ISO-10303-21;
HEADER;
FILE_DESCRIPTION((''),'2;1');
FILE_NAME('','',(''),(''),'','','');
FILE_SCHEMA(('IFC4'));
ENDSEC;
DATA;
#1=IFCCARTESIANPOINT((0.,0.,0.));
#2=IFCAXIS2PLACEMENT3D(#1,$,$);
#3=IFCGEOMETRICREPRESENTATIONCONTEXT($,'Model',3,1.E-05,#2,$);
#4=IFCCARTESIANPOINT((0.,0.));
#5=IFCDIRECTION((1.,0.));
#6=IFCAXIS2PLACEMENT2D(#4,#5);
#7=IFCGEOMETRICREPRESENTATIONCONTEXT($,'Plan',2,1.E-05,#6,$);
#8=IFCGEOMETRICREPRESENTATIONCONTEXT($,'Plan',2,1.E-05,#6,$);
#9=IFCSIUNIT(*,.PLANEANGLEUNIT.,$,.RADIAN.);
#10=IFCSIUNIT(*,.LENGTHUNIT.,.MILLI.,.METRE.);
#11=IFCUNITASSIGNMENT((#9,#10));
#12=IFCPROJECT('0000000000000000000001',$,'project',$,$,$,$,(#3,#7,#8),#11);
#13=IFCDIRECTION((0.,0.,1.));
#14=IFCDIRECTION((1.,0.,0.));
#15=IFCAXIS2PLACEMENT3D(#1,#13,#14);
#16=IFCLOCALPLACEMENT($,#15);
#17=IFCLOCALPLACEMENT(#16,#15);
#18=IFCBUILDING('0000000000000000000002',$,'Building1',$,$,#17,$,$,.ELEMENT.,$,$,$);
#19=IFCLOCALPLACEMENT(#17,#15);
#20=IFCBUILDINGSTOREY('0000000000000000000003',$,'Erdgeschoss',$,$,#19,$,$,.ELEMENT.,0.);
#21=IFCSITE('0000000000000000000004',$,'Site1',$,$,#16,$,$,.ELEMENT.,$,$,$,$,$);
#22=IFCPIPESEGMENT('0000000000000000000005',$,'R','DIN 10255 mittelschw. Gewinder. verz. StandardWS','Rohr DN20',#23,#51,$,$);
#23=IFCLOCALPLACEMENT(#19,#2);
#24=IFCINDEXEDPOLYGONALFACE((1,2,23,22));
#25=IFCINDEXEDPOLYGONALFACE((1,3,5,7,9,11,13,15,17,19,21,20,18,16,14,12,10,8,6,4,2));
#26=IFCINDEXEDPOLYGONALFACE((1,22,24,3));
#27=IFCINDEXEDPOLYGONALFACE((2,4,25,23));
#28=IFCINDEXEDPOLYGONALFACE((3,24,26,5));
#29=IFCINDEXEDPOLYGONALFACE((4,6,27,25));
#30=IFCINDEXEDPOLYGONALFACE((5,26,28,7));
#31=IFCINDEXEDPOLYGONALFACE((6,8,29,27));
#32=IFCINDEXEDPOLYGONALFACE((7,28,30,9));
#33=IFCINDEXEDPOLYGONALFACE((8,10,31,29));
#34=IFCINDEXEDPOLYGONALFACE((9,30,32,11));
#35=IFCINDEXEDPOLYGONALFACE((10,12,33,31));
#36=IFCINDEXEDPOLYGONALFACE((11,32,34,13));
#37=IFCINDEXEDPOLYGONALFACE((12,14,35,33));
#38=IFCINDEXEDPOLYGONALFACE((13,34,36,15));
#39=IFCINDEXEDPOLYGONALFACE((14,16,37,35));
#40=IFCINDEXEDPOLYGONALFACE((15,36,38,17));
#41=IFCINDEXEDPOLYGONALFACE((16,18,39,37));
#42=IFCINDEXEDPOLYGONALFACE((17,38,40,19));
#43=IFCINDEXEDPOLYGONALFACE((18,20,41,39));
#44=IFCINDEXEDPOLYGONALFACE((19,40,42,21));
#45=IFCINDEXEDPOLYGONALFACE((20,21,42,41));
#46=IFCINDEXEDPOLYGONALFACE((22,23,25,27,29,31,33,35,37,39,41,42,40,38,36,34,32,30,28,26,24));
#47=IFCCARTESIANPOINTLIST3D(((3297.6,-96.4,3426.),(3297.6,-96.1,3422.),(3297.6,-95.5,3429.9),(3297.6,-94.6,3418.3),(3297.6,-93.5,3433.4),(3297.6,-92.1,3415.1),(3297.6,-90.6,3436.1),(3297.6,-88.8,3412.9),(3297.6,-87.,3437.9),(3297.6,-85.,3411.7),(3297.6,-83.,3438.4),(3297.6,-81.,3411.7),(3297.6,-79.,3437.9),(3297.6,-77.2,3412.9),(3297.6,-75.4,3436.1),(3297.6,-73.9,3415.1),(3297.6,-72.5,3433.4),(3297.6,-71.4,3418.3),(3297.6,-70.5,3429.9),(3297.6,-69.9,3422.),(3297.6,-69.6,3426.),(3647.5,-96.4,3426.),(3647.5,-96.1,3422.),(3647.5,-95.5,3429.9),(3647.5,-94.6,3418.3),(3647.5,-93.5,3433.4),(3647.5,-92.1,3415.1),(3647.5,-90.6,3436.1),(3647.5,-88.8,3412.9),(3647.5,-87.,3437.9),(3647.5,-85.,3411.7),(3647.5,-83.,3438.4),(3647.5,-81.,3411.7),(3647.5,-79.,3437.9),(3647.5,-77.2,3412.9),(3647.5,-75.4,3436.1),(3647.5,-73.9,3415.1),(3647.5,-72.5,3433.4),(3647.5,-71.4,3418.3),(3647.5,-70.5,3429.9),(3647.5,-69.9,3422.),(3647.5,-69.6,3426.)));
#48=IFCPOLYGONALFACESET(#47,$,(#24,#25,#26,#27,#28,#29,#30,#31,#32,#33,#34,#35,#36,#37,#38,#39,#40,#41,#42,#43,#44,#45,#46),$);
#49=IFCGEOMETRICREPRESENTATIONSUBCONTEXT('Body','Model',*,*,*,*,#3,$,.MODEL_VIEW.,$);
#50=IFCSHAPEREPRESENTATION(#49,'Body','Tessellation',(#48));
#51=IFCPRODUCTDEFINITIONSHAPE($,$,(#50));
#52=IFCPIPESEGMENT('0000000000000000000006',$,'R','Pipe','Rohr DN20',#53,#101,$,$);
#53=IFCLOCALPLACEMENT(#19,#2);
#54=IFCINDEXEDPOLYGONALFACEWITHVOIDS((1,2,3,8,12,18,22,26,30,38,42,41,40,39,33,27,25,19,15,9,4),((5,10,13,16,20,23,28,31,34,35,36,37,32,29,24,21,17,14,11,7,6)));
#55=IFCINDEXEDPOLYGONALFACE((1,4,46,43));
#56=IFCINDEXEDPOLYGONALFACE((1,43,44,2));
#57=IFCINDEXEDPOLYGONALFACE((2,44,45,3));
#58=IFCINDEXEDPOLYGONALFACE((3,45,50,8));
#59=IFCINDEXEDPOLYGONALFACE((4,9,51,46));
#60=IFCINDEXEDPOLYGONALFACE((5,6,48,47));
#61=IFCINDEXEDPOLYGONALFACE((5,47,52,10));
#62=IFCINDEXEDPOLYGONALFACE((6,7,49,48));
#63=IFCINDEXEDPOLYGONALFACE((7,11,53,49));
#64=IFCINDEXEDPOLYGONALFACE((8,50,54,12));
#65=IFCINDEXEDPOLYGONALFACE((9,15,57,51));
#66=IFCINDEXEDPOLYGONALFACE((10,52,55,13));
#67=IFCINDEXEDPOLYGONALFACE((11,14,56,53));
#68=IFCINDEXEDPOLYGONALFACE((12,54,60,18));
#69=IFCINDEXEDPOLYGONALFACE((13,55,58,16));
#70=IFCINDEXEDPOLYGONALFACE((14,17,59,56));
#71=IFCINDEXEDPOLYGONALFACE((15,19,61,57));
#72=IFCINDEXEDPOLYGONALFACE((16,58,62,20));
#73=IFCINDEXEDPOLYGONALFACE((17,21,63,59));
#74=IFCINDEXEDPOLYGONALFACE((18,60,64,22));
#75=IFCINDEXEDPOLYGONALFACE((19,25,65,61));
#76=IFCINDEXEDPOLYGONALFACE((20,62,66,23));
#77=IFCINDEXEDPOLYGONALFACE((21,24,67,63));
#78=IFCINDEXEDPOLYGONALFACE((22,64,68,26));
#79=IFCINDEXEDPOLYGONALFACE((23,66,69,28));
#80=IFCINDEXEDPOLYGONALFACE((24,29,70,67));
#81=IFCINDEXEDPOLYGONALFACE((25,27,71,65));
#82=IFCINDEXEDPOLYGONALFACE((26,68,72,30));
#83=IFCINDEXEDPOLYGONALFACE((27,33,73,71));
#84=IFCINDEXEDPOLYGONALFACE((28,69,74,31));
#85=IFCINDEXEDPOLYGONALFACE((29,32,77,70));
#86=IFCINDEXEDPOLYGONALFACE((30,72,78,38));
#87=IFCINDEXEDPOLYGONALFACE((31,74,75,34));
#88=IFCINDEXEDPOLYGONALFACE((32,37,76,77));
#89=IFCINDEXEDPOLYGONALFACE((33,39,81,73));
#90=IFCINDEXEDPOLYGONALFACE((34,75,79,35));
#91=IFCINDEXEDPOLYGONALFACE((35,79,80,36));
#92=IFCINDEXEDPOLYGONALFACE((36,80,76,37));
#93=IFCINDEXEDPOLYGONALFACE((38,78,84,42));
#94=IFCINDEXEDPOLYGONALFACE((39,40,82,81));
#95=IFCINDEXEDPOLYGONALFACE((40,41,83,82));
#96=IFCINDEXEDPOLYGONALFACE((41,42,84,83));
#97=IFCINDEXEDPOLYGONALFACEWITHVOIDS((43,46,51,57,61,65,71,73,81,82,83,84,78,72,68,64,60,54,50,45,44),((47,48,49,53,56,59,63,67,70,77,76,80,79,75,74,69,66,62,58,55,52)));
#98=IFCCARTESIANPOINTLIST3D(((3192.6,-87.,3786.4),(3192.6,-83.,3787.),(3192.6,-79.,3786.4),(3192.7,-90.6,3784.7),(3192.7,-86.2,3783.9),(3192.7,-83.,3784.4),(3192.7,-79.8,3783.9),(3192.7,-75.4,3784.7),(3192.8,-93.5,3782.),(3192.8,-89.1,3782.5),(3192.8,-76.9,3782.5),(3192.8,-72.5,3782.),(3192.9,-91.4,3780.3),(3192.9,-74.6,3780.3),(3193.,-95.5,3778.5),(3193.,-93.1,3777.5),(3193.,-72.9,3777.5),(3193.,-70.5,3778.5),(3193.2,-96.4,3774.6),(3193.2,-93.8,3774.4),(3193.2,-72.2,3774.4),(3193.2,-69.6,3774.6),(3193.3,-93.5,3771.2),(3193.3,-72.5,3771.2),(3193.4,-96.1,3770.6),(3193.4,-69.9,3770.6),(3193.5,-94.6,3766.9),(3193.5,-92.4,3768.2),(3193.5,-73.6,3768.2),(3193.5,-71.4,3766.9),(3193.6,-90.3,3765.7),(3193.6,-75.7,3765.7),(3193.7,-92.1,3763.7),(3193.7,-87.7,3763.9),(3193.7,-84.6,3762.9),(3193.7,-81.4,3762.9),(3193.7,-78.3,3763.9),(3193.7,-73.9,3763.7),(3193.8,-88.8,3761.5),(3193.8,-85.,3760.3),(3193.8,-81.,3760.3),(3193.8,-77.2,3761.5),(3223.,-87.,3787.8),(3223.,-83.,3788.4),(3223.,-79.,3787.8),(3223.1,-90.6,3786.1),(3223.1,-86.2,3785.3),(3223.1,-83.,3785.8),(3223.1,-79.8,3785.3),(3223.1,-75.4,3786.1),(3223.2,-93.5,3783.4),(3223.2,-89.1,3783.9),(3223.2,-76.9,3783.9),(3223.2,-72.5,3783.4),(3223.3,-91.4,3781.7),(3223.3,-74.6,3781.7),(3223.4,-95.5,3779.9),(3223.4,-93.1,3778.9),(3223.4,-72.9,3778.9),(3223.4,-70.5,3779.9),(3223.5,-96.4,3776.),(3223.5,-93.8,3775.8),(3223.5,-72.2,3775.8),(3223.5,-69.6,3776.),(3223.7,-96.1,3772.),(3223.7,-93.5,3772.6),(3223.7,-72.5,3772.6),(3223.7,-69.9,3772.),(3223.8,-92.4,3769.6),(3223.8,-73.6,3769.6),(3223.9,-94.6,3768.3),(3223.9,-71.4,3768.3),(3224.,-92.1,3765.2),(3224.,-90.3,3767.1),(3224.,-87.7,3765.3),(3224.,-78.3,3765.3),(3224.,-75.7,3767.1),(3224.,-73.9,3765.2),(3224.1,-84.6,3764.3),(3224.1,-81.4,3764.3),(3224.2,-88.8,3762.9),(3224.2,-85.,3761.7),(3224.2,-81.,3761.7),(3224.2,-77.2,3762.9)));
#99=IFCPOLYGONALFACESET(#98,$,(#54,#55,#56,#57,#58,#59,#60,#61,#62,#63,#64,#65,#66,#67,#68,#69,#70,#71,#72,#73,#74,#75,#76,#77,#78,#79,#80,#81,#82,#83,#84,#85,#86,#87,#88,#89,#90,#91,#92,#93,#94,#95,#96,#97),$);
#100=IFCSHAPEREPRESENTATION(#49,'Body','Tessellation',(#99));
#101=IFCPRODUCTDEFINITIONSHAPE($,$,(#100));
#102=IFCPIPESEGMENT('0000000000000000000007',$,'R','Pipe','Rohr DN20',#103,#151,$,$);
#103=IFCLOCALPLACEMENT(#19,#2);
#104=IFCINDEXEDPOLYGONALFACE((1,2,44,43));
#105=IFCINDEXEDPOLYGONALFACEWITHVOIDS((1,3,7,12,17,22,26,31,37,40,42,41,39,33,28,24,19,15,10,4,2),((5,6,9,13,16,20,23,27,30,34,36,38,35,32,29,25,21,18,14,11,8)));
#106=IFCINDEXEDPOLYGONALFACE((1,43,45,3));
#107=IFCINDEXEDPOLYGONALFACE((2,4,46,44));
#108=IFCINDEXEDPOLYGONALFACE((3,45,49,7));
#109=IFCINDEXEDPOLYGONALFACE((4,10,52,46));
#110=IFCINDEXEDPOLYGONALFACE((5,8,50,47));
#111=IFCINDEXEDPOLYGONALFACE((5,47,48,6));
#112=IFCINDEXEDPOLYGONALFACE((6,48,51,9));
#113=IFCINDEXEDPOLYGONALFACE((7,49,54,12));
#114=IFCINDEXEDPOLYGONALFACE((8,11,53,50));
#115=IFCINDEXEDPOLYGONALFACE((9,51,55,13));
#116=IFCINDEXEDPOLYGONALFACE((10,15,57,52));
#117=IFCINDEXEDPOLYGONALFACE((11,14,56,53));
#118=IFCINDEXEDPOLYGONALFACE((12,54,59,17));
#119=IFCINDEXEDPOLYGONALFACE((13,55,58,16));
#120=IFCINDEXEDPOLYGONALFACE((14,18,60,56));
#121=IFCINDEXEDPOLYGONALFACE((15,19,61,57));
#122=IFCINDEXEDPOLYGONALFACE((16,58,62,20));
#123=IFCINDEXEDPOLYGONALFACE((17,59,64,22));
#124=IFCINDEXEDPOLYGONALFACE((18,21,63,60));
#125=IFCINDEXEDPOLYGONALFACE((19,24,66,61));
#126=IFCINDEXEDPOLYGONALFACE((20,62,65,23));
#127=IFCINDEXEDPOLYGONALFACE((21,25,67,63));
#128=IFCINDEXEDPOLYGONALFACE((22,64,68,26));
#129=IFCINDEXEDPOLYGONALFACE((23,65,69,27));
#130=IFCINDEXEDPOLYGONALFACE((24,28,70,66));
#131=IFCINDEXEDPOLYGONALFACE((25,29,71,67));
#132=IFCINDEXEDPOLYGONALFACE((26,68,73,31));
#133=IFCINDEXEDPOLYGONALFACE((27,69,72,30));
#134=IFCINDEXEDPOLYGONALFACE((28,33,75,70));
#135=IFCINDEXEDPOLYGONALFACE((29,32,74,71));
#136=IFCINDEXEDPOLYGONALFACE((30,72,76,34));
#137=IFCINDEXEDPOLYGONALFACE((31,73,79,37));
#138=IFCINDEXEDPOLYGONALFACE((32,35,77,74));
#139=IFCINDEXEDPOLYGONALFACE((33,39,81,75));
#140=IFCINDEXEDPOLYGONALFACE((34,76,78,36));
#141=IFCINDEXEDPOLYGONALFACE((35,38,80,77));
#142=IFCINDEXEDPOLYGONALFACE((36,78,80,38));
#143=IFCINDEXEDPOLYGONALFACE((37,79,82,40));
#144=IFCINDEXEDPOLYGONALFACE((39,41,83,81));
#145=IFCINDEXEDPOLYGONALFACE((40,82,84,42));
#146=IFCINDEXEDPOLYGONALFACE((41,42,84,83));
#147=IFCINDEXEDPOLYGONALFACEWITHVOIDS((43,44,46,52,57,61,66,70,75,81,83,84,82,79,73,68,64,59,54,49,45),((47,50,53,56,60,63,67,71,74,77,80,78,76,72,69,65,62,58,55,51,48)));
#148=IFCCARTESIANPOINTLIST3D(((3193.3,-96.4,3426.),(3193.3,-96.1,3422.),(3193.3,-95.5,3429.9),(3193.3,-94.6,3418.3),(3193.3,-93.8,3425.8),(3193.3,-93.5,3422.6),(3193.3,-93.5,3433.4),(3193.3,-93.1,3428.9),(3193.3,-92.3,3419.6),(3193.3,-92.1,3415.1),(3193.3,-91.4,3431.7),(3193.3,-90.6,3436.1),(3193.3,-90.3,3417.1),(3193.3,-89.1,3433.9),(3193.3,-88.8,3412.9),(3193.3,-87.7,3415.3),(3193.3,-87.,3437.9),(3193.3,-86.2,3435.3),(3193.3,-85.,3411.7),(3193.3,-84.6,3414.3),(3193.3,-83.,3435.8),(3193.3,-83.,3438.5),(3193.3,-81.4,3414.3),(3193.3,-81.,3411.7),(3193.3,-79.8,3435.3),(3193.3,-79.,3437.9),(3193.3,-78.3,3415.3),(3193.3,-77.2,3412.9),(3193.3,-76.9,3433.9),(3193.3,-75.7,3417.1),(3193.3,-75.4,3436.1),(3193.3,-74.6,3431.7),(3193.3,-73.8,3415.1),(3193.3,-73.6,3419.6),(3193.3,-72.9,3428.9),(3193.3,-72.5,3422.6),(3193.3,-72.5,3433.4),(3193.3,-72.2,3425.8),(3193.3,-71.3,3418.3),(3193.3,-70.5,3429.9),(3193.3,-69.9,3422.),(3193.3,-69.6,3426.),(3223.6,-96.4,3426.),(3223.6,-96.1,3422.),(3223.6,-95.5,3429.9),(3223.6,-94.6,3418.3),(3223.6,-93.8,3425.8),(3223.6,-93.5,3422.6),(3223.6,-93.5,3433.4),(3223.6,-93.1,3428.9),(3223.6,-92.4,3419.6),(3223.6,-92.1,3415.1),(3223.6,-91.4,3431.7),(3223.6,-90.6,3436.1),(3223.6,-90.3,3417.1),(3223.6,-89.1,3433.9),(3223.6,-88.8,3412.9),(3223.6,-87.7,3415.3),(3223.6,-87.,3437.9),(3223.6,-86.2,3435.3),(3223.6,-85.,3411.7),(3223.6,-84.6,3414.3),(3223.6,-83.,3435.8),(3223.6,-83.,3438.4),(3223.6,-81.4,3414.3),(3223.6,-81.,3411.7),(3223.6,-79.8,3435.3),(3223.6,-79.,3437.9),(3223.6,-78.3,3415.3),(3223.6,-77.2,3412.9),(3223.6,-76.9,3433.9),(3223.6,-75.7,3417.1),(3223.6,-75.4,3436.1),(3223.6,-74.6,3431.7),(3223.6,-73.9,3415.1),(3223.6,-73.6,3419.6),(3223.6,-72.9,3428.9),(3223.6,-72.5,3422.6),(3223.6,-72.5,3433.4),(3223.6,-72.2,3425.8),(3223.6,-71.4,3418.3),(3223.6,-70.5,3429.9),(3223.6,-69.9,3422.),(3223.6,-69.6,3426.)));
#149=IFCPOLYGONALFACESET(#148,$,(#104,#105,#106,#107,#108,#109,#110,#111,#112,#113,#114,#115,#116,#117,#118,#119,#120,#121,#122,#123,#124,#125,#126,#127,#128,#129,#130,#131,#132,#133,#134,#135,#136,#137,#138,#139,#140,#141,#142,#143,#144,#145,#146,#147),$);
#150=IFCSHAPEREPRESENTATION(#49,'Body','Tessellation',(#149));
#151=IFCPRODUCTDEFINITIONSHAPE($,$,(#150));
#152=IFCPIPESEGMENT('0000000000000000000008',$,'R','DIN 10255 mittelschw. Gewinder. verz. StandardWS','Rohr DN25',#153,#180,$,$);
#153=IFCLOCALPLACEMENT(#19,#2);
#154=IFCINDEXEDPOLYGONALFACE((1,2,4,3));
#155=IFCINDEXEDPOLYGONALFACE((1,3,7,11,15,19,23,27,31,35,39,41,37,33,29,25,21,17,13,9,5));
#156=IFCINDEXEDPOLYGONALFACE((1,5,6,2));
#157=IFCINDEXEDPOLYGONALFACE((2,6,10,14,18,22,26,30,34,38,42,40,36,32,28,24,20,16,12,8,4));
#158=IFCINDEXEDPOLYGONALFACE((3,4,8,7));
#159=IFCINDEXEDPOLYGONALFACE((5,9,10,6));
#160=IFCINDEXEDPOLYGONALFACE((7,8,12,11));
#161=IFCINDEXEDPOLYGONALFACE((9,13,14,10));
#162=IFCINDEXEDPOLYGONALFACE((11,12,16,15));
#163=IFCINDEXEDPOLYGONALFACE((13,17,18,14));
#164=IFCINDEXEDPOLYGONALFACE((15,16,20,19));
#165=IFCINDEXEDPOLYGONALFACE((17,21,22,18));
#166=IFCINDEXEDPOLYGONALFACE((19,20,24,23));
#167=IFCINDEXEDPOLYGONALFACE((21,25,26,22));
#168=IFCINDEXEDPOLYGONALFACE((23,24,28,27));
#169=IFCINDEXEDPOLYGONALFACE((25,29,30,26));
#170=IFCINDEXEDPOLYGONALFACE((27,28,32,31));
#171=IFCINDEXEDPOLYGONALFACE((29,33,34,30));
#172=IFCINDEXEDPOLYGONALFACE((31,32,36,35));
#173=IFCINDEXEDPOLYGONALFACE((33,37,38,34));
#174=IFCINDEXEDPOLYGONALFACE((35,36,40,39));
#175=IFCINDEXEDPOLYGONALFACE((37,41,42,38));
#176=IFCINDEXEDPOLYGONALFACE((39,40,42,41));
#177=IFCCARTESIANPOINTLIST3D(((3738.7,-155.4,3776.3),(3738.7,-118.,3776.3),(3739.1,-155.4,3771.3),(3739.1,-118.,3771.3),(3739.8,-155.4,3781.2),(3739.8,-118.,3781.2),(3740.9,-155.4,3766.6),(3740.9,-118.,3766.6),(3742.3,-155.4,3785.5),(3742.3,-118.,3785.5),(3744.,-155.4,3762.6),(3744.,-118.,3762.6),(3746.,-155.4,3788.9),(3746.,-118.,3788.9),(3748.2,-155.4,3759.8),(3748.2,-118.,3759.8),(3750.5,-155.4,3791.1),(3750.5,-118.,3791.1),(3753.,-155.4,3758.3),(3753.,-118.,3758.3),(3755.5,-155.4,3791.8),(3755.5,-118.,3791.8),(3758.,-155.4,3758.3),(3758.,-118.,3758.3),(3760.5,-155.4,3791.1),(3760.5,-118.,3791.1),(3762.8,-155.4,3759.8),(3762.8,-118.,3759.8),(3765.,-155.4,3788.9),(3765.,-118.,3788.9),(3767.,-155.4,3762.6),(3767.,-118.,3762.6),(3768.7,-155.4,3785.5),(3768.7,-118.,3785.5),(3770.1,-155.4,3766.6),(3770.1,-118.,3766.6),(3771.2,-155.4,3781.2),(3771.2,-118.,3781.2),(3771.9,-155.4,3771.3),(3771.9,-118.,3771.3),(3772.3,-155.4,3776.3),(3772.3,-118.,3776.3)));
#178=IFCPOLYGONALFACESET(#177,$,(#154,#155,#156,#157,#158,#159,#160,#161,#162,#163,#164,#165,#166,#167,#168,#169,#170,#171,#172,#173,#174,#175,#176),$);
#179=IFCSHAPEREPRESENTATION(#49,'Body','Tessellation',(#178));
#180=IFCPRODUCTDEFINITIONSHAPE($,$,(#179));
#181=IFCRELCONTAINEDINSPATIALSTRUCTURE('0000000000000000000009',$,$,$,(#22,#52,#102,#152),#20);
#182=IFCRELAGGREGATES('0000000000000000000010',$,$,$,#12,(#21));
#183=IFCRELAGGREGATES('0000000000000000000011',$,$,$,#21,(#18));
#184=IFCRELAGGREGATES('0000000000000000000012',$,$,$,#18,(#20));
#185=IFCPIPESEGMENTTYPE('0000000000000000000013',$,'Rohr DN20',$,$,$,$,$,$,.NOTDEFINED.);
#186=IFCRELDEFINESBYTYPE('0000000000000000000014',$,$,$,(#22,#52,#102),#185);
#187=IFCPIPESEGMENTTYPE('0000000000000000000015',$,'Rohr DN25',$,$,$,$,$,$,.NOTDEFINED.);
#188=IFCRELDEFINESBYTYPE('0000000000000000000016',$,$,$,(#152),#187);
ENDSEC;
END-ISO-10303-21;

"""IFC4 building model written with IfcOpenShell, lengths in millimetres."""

from ifc_helpers import new_model, si_unit, frame, origin, origin_with_axes, origin_2d_with_axis, place, context, subcontext, project, spatial, circle, hollow_circle, extrude, type_object, element, save


model = new_model("IFC4")

# Units and contexts
model_context = context("Model", 3, precision=1e-05, world=origin())
plan_context_1 = context("Plan", 2, precision=1e-05, world=origin_2d_with_axis())
plan_context_2 = context("Plan", 2, precision=1e-05, world=origin_2d_with_axis())
body_context = subcontext(model_context, "Body", "Model", "MODEL_VIEW")
ifc_project = project(units=[si_unit("PLANEANGLEUNIT", "RADIAN"), si_unit("LENGTHUNIT", "METRE", prefix="MILLI")], contexts=[model_context, plan_context_1, plan_context_2])

# Site, building, storey
site_placement = place(None, origin_with_axes())
site = spatial("IfcSite", under=ifc_project, at=site_placement, Name="Site1", CompositionType="ELEMENT")
building_placement = place(site_placement, origin_with_axes())
building = spatial("IfcBuilding", under=site, at=building_placement, Name="Building1", CompositionType="ELEMENT")
storey_placement = place(building_placement, origin_with_axes())
storey = spatial("IfcBuildingStorey", under=building, at=storey_placement, Name="Erdgeschoss", CompositionType="ELEMENT", Elevation=0.0)

# Pipe segments
pipe_segment_type_1 = type_object("IfcPipeSegmentType", Name="Rohr DN20", PredefinedType="NOTDEFINED")
pipe_segment_1_placement = place(storey_placement, frame((3472.5, -83.2, 3425.0), z_axis=(0.0, 0.0, 1.0), x_axis=(1.0, 0.0, 0.0)))
element("IfcPipeSegment", 1, at=pipe_segment_1_placement, inside=storey, type_object=pipe_segment_type_1, Name="R", Description="DIN 10255 mittelschw. Gewinder. verz. StandardWS", ObjectType="Rohr DN20", context=body_context, shape_type="SolidModel", body=[
    extrude(circle(Radius=13.4, at=origin_2d_with_axis()), frame((175.0, 0.2, 0.0), z_axis=(-1.0, 0.0, 0.0), x_axis=(0.0, 0.0, 1.0)), (0.0, 0.0, 1.0), 349.9),
])
pipe_segment_2_placement = place(storey_placement, frame((3208.4, -82.8, 3774.3), z_axis=(0.0, 0.0, 1.0), x_axis=(1.0, 0.0, 0.0)))
element("IfcPipeSegment", 2, at=pipe_segment_2_placement, inside=storey, type_object=pipe_segment_type_1, Name="R", Description="Pipe", ObjectType="Rohr DN20", context=body_context, shape_type="SolidModel", body=[
    extrude(hollow_circle(Radius=13.4, WallThickness=2.6, at=origin_2d_with_axis()), frame((-15.2, -0.1, -0.7), z_axis=(0.998901, 0.0, 0.046868), x_axis=(0.0, 0.0, 1.0)), (0.0, 0.0, 1.0), 30.4),
])
pipe_segment_3_placement = place(storey_placement, frame((3208.4, -82.8, 3425.0), z_axis=(0.0, 0.0, 1.0), x_axis=(1.0, 0.0, 0.0)))
element("IfcPipeSegment", 3, at=pipe_segment_3_placement, inside=storey, type_object=pipe_segment_type_1, Name="R", Description="Pipe", ObjectType="Rohr DN20", context=body_context, shape_type="SolidModel", body=[
    extrude(hollow_circle(Radius=13.4, WallThickness=2.6, at=origin_2d_with_axis()), frame((-15.2, -0.1, 0.0), z_axis=(1.0, -0.000108, -0.000078), x_axis=(0.0, 0.0, 1.0)), (0.0, 0.0, 1.0), 30.3),
])
pipe_segment_type_2 = type_object("IfcPipeSegmentType", Name="Rohr DN25", PredefinedType="NOTDEFINED")
pipe_segment_4_placement = place(storey_placement, frame((3755.6, -136.7, 3775.0), z_axis=(0.0, 0.0, 1.0), x_axis=(1.0, 0.0, 0.0)))
element("IfcPipeSegment", 4, at=pipe_segment_4_placement, inside=storey, type_object=pipe_segment_type_2, Name="R", Description="DIN 10255 mittelschw. Gewinder. verz. StandardWS", ObjectType="Rohr DN25", context=body_context, shape_type="SolidModel", body=[
    extrude(circle(Radius=16.9, at=origin_2d_with_axis()), frame((-0.1, 18.7, 0.0), z_axis=(0.0, -1.0, 0.0), x_axis=(0.0, 0.0, 1.0)), (0.0, 0.0, 1.0), 37.4),
])

save(model, "model.ifc")
